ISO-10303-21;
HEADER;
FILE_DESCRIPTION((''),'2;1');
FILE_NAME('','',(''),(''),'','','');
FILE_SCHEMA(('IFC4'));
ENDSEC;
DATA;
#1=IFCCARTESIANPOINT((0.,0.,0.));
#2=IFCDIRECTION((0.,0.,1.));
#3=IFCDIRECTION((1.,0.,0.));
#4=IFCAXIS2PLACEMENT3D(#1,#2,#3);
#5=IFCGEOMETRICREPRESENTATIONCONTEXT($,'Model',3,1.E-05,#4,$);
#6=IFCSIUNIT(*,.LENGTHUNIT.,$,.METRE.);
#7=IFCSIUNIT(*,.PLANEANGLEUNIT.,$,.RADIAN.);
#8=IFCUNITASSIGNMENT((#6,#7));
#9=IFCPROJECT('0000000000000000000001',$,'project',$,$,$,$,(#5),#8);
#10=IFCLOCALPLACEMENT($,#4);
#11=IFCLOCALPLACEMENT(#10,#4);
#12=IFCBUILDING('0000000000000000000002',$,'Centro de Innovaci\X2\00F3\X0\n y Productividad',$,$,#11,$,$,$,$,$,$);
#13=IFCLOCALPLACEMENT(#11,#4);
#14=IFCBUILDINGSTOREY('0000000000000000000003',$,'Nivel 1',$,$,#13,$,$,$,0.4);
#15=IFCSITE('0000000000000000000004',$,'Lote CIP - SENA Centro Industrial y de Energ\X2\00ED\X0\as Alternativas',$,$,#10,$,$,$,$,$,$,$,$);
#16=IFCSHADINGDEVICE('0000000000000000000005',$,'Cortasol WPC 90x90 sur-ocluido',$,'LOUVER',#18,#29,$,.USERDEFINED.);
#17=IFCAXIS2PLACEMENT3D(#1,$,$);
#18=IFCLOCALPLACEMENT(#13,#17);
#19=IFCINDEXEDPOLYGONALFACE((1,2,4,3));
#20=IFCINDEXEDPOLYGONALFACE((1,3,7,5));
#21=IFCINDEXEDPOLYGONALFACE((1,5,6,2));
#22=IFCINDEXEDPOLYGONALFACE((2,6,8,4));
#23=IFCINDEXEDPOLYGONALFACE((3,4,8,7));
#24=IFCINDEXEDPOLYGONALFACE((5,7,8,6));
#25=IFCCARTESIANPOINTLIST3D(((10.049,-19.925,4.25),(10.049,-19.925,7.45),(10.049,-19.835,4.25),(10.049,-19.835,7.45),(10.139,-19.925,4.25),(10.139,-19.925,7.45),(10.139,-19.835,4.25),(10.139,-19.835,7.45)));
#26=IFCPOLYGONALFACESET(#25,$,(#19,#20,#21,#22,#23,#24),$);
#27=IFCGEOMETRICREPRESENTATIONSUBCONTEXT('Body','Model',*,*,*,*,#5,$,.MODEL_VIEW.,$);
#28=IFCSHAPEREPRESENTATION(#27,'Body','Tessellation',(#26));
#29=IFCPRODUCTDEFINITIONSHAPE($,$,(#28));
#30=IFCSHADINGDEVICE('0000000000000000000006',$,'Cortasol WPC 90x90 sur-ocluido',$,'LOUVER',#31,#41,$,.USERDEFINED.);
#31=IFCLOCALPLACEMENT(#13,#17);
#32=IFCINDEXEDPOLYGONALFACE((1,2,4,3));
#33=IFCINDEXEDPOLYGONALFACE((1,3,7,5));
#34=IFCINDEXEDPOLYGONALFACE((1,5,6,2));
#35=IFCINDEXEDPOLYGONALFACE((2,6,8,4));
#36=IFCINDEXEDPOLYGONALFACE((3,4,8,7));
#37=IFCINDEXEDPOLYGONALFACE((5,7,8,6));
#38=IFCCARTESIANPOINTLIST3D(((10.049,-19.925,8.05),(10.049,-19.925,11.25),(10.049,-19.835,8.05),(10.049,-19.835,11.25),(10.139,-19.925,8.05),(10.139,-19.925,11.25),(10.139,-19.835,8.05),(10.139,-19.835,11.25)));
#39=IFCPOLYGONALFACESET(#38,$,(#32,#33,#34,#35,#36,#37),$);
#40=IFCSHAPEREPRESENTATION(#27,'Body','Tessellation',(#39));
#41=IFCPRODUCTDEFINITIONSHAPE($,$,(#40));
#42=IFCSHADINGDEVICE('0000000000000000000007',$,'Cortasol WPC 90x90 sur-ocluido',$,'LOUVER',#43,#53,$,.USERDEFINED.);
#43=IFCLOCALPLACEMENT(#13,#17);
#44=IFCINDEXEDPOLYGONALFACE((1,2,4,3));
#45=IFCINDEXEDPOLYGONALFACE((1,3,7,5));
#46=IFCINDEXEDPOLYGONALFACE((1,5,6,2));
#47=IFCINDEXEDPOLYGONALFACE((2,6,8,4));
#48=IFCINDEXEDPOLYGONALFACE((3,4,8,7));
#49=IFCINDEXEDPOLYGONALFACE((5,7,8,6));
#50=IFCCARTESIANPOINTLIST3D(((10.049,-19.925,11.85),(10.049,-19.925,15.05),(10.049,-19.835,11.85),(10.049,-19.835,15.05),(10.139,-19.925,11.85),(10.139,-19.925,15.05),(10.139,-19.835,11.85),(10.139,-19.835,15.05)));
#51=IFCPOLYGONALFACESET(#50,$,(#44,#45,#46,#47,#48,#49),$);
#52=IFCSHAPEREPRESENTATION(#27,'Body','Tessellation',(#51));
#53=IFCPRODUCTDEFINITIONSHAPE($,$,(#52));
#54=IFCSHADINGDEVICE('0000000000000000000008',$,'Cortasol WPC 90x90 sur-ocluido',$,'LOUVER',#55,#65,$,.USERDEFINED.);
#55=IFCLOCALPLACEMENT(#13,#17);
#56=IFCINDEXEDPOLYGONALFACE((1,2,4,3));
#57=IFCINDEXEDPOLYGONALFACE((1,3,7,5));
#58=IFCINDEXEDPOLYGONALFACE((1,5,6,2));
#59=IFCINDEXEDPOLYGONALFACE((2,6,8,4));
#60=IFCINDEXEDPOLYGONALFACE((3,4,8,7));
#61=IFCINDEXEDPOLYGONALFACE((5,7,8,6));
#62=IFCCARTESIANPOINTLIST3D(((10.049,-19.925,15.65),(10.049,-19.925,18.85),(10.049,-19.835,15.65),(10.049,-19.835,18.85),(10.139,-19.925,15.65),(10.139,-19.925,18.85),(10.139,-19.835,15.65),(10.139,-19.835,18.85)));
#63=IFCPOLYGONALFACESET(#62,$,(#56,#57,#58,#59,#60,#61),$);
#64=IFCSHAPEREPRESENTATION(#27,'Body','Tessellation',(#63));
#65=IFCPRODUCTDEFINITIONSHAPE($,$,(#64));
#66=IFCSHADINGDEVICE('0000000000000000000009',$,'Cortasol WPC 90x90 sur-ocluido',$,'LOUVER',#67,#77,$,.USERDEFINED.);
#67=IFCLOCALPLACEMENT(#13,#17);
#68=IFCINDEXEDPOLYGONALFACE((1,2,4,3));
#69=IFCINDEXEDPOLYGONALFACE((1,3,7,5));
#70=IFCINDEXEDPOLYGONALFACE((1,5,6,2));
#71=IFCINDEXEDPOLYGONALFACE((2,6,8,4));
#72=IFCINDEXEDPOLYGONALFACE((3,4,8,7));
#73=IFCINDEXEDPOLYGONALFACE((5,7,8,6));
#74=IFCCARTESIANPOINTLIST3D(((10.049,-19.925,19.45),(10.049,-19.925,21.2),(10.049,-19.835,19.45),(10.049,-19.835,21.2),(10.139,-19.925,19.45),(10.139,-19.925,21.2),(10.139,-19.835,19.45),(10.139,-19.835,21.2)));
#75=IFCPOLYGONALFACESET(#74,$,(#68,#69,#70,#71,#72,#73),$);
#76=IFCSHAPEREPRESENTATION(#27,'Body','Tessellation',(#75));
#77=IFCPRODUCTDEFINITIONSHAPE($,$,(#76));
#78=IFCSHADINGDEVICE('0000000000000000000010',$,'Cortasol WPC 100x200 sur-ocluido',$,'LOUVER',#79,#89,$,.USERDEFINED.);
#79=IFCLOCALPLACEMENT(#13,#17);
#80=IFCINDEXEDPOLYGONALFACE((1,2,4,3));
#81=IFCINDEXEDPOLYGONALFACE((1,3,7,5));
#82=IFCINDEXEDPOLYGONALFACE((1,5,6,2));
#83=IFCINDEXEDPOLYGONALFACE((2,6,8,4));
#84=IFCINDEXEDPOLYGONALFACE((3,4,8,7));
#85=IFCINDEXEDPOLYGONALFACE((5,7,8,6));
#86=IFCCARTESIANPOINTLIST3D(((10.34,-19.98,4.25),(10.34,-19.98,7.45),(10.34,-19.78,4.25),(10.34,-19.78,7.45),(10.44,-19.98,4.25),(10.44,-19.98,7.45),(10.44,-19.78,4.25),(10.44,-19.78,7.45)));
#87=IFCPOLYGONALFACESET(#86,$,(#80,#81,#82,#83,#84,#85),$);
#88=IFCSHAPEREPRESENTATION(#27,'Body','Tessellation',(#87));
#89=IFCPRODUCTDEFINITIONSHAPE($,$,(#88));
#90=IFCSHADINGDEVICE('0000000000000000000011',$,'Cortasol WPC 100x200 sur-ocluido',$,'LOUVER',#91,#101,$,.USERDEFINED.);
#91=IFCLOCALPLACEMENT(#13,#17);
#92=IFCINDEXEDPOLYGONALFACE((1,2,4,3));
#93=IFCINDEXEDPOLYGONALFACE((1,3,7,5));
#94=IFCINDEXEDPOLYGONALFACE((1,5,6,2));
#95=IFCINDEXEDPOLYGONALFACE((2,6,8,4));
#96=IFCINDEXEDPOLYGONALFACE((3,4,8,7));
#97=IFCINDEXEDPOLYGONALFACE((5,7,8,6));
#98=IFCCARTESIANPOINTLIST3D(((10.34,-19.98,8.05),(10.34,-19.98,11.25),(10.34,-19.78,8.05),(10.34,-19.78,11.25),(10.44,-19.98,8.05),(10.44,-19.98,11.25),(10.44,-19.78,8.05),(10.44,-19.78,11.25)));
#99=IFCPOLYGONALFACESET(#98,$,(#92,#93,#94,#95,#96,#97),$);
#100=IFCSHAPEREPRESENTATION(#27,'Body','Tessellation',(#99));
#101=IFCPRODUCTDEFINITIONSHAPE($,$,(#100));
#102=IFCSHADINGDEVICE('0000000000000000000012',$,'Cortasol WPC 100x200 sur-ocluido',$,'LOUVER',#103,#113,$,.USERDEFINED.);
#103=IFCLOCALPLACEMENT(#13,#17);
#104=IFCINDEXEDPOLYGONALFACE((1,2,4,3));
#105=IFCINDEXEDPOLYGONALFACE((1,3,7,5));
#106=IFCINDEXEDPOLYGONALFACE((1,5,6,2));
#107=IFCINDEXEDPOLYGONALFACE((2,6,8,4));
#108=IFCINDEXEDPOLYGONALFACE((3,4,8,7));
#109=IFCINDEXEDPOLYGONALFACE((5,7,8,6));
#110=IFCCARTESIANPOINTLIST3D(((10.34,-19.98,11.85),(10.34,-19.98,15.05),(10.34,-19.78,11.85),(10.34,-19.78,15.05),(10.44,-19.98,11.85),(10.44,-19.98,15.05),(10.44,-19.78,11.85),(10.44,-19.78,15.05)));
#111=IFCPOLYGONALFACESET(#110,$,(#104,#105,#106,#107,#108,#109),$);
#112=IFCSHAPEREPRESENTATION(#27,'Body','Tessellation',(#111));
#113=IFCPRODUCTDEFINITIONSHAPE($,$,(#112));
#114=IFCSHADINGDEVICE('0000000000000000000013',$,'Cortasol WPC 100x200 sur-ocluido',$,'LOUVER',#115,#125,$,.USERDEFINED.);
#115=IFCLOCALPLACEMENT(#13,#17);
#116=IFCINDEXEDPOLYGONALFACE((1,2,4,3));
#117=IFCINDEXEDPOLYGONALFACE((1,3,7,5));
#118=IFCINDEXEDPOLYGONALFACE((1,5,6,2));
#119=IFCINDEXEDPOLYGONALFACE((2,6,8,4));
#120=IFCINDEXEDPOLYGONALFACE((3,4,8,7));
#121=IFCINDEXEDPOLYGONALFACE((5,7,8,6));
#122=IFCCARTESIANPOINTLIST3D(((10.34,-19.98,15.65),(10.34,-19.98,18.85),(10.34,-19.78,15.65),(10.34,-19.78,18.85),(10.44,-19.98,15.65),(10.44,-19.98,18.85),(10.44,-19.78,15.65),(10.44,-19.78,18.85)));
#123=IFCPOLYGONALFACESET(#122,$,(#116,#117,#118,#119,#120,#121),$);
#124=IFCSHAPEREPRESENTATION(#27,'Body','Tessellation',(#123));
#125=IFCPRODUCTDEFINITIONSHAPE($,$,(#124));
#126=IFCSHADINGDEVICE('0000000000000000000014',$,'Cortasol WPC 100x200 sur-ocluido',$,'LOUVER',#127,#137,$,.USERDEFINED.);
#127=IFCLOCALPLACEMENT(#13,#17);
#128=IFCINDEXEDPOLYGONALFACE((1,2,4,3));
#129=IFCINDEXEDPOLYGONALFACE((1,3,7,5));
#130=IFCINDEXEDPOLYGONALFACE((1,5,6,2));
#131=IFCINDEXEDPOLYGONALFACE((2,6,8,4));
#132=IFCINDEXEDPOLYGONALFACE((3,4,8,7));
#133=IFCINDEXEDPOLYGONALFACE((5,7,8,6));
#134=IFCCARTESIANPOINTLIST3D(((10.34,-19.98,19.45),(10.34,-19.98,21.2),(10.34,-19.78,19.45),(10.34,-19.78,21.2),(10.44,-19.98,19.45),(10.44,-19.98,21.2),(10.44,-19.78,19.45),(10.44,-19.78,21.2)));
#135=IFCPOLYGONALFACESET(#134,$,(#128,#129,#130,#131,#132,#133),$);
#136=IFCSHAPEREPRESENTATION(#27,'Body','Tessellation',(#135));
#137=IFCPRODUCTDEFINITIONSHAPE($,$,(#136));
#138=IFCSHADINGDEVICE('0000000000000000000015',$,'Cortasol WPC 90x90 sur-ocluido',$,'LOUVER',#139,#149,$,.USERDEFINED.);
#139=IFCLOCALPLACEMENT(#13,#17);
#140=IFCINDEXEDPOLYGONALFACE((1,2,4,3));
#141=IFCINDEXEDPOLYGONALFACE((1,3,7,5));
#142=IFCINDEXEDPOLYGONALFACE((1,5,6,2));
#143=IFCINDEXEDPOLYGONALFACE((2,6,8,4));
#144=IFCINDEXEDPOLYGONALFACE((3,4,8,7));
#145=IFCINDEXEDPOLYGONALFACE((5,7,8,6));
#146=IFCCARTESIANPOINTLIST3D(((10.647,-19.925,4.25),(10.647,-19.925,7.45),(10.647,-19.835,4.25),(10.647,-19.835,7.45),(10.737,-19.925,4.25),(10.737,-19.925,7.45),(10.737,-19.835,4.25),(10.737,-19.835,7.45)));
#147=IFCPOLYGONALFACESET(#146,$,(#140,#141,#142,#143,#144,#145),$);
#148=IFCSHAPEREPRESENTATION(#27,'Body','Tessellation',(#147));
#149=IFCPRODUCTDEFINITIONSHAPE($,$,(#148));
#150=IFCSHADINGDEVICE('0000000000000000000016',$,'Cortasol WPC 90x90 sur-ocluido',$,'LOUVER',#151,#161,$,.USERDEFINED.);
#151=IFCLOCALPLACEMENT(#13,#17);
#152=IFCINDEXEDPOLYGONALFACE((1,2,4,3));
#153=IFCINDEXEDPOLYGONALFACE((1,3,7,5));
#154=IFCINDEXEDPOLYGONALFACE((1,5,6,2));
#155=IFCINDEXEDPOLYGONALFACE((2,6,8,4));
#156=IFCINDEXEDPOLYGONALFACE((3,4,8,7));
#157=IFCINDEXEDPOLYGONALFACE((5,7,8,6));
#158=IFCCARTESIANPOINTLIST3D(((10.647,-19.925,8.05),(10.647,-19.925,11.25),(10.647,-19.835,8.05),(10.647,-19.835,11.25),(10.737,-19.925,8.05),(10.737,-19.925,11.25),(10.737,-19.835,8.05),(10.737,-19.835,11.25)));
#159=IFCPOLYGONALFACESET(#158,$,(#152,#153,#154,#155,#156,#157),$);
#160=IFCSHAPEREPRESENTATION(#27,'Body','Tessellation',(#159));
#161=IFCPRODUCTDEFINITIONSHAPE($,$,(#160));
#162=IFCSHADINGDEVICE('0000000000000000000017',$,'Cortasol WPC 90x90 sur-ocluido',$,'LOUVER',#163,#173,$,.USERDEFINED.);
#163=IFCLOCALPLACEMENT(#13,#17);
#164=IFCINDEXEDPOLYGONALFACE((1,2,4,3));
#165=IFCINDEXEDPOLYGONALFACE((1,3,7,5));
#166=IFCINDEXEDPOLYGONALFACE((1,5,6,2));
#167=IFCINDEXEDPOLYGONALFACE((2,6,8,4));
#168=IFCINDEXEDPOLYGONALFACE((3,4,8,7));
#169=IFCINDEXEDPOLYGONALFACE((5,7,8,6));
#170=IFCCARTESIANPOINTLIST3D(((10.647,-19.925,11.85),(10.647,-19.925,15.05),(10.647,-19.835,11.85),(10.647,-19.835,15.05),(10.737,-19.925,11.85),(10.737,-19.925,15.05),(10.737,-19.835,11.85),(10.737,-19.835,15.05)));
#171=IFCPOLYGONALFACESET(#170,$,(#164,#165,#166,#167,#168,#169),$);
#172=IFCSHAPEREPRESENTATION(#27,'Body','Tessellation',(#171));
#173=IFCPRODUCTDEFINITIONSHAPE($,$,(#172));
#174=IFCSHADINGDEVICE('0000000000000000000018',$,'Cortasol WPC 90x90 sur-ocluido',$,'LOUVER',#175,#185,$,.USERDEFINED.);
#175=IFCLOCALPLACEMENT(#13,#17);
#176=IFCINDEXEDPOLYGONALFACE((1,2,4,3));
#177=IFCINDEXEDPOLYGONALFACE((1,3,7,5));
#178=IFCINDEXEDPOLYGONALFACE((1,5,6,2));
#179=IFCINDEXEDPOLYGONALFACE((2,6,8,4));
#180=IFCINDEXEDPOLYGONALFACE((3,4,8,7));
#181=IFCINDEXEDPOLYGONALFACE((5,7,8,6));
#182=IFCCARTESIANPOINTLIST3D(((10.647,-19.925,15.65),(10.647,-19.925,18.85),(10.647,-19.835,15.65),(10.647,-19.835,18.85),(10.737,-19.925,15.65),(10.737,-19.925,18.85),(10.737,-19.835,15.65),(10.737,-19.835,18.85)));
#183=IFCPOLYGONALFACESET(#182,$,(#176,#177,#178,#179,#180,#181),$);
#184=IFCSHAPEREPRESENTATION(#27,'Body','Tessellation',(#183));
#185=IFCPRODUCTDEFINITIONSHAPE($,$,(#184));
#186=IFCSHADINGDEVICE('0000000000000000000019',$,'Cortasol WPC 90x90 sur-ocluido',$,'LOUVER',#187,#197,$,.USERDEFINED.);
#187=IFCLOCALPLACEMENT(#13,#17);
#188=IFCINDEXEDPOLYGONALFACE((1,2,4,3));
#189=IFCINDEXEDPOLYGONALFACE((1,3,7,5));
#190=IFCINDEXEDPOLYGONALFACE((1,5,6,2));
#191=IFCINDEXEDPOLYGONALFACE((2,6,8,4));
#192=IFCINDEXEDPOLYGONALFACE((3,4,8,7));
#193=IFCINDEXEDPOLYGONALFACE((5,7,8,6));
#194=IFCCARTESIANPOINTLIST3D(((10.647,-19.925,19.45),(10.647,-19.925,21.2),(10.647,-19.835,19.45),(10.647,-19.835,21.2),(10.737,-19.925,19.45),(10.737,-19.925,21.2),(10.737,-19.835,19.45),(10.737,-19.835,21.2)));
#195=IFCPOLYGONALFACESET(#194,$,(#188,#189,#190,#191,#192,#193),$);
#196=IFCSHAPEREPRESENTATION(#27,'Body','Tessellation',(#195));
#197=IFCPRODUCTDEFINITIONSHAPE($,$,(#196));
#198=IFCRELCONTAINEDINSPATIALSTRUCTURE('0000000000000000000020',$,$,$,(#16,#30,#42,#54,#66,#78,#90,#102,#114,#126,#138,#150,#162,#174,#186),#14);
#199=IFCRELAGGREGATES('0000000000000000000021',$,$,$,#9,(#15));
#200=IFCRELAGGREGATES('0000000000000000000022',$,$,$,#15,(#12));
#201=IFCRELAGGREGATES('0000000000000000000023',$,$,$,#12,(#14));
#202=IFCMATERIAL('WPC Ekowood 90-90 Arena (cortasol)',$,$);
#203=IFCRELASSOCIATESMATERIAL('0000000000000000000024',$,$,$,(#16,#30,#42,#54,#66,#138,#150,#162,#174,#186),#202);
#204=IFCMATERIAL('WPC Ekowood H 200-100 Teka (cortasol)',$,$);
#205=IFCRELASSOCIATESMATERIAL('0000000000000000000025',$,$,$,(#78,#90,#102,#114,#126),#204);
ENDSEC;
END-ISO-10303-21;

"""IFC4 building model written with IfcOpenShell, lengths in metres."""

from ifc_helpers import new_model, si_unit, frame, origin_with_axes, place, context, subcontext, project, spatial, polyline, outline, extrude, material, element, save


model = new_model("IFC4")

# Units and contexts
model_context = context("Model", 3, precision=1e-05, world=origin_with_axes())
body_context = subcontext(model_context, "Body", "Model", "MODEL_VIEW")
ifc_project = project(units=[si_unit("LENGTHUNIT", "METRE"), si_unit("PLANEANGLEUNIT", "RADIAN")], contexts=[model_context])

# Site, building, storey
site_placement = place(None, origin_with_axes())
site = spatial("IfcSite", under=ifc_project, at=site_placement, Name="Lote CIP - SENA Centro Industrial y de Energías Alternativas")
building_placement = place(site_placement, origin_with_axes())
building = spatial("IfcBuilding", under=site, at=building_placement, Name="Centro de Innovación y Productividad")
storey_placement = place(building_placement, origin_with_axes())
storey = spatial("IfcBuildingStorey", under=building, at=storey_placement, Name="Nivel 1", Elevation=0.4)

# Shading devices
ifc_material_1 = material(Name="WPC Ekowood 90-90 Arena (cortasol)")
shading_device_1_placement = place(storey_placement, origin_with_axes())
element("IfcShadingDevice", 1, at=shading_device_1_placement, inside=storey, material=ifc_material_1, Name="Cortasol WPC 90x90 sur-ocluido", ObjectType="LOUVER", PredefinedType="USERDEFINED", context=body_context, shape_type="SweptSolid", body=[
    extrude(outline(polyline([(10.049, -19.925), (10.049, -19.835), (10.139, -19.835), (10.139, -19.925), (10.049, -19.925)])), frame((0.0, 0.0, 4.25)), (0.0, 0.0, 1.0), 3.2),
])
shading_device_2_placement = place(storey_placement, origin_with_axes())
element("IfcShadingDevice", 2, at=shading_device_2_placement, inside=storey, material=ifc_material_1, Name="Cortasol WPC 90x90 sur-ocluido", ObjectType="LOUVER", PredefinedType="USERDEFINED", context=body_context, shape_type="SweptSolid", body=[
    extrude(outline(polyline([(10.049, -19.925), (10.049, -19.835), (10.139, -19.835), (10.139, -19.925), (10.049, -19.925)])), frame((0.0, 0.0, 8.05)), (0.0, 0.0, 1.0), 3.2),
])
shading_device_3_placement = place(storey_placement, origin_with_axes())
element("IfcShadingDevice", 3, at=shading_device_3_placement, inside=storey, material=ifc_material_1, Name="Cortasol WPC 90x90 sur-ocluido", ObjectType="LOUVER", PredefinedType="USERDEFINED", context=body_context, shape_type="SweptSolid", body=[
    extrude(outline(polyline([(10.049, -19.925), (10.049, -19.835), (10.139, -19.835), (10.139, -19.925), (10.049, -19.925)])), frame((0.0, 0.0, 11.85)), (0.0, 0.0, 1.0), 3.2),
])
shading_device_4_placement = place(storey_placement, origin_with_axes())
element("IfcShadingDevice", 4, at=shading_device_4_placement, inside=storey, material=ifc_material_1, Name="Cortasol WPC 90x90 sur-ocluido", ObjectType="LOUVER", PredefinedType="USERDEFINED", context=body_context, shape_type="SweptSolid", body=[
    extrude(outline(polyline([(10.049, -19.925), (10.049, -19.835), (10.139, -19.835), (10.139, -19.925), (10.049, -19.925)])), frame((0.0, 0.0, 15.65)), (0.0, 0.0, 1.0), 3.2),
])
shading_device_5_placement = place(storey_placement, origin_with_axes())
element("IfcShadingDevice", 5, at=shading_device_5_placement, inside=storey, material=ifc_material_1, Name="Cortasol WPC 90x90 sur-ocluido", ObjectType="LOUVER", PredefinedType="USERDEFINED", context=body_context, shape_type="SweptSolid", body=[
    extrude(outline(polyline([(10.049, -19.925), (10.049, -19.835), (10.139, -19.835), (10.139, -19.925), (10.049, -19.925)])), frame((0.0, 0.0, 19.45)), (0.0, 0.0, 1.0), 1.75),
])
ifc_material_2 = material(Name="WPC Ekowood H 200-100 Teka (cortasol)")
shading_device_6_placement = place(storey_placement, origin_with_axes())
element("IfcShadingDevice", 6, at=shading_device_6_placement, inside=storey, material=ifc_material_2, Name="Cortasol WPC 100x200 sur-ocluido", ObjectType="LOUVER", PredefinedType="USERDEFINED", context=body_context, shape_type="SweptSolid", body=[
    extrude(outline(polyline([(10.34, -19.98), (10.34, -19.78), (10.44, -19.78), (10.44, -19.98), (10.34, -19.98)])), frame((0.0, 0.0, 4.25)), (0.0, 0.0, 1.0), 3.2),
])
shading_device_7_placement = place(storey_placement, origin_with_axes())
element("IfcShadingDevice", 7, at=shading_device_7_placement, inside=storey, material=ifc_material_2, Name="Cortasol WPC 100x200 sur-ocluido", ObjectType="LOUVER", PredefinedType="USERDEFINED", context=body_context, shape_type="SweptSolid", body=[
    extrude(outline(polyline([(10.34, -19.98), (10.34, -19.78), (10.44, -19.78), (10.44, -19.98), (10.34, -19.98)])), frame((0.0, 0.0, 8.05)), (0.0, 0.0, 1.0), 3.2),
])
shading_device_8_placement = place(storey_placement, origin_with_axes())
element("IfcShadingDevice", 8, at=shading_device_8_placement, inside=storey, material=ifc_material_2, Name="Cortasol WPC 100x200 sur-ocluido", ObjectType="LOUVER", PredefinedType="USERDEFINED", context=body_context, shape_type="SweptSolid", body=[
    extrude(outline(polyline([(10.34, -19.98), (10.34, -19.78), (10.44, -19.78), (10.44, -19.98), (10.34, -19.98)])), frame((0.0, 0.0, 11.85)), (0.0, 0.0, 1.0), 3.2),
])
shading_device_9_placement = place(storey_placement, origin_with_axes())
element("IfcShadingDevice", 9, at=shading_device_9_placement, inside=storey, material=ifc_material_2, Name="Cortasol WPC 100x200 sur-ocluido", ObjectType="LOUVER", PredefinedType="USERDEFINED", context=body_context, shape_type="SweptSolid", body=[
    extrude(outline(polyline([(10.34, -19.98), (10.34, -19.78), (10.44, -19.78), (10.44, -19.98), (10.34, -19.98)])), frame((0.0, 0.0, 15.65)), (0.0, 0.0, 1.0), 3.2),
])
shading_device_10_placement = place(storey_placement, origin_with_axes())
element("IfcShadingDevice", 10, at=shading_device_10_placement, inside=storey, material=ifc_material_2, Name="Cortasol WPC 100x200 sur-ocluido", ObjectType="LOUVER", PredefinedType="USERDEFINED", context=body_context, shape_type="SweptSolid", body=[
    extrude(outline(polyline([(10.34, -19.98), (10.34, -19.78), (10.44, -19.78), (10.44, -19.98), (10.34, -19.98)])), frame((0.0, 0.0, 19.45)), (0.0, 0.0, 1.0), 1.75),
])
shading_device_11_placement = place(storey_placement, origin_with_axes())
element("IfcShadingDevice", 11, at=shading_device_11_placement, inside=storey, material=ifc_material_1, Name="Cortasol WPC 90x90 sur-ocluido", ObjectType="LOUVER", PredefinedType="USERDEFINED", context=body_context, shape_type="SweptSolid", body=[
    extrude(outline(polyline([(10.647, -19.925), (10.647, -19.835), (10.737, -19.835), (10.737, -19.925), (10.647, -19.925)])), frame((0.0, 0.0, 4.25)), (0.0, 0.0, 1.0), 3.2),
])
shading_device_12_placement = place(storey_placement, origin_with_axes())
element("IfcShadingDevice", 12, at=shading_device_12_placement, inside=storey, material=ifc_material_1, Name="Cortasol WPC 90x90 sur-ocluido", ObjectType="LOUVER", PredefinedType="USERDEFINED", context=body_context, shape_type="SweptSolid", body=[
    extrude(outline(polyline([(10.647, -19.925), (10.647, -19.835), (10.737, -19.835), (10.737, -19.925), (10.647, -19.925)])), frame((0.0, 0.0, 8.05)), (0.0, 0.0, 1.0), 3.2),
])
shading_device_13_placement = place(storey_placement, origin_with_axes())
element("IfcShadingDevice", 13, at=shading_device_13_placement, inside=storey, material=ifc_material_1, Name="Cortasol WPC 90x90 sur-ocluido", ObjectType="LOUVER", PredefinedType="USERDEFINED", context=body_context, shape_type="SweptSolid", body=[
    extrude(outline(polyline([(10.647, -19.925), (10.647, -19.835), (10.737, -19.835), (10.737, -19.925), (10.647, -19.925)])), frame((0.0, 0.0, 11.85)), (0.0, 0.0, 1.0), 3.2),
])
shading_device_14_placement = place(storey_placement, origin_with_axes())
element("IfcShadingDevice", 14, at=shading_device_14_placement, inside=storey, material=ifc_material_1, Name="Cortasol WPC 90x90 sur-ocluido", ObjectType="LOUVER", PredefinedType="USERDEFINED", context=body_context, shape_type="SweptSolid", body=[
    extrude(outline(polyline([(10.647, -19.925), (10.647, -19.835), (10.737, -19.835), (10.737, -19.925), (10.647, -19.925)])), frame((0.0, 0.0, 15.65)), (0.0, 0.0, 1.0), 3.2),
])
shading_device_15_placement = place(storey_placement, origin_with_axes())
element("IfcShadingDevice", 15, at=shading_device_15_placement, inside=storey, material=ifc_material_1, Name="Cortasol WPC 90x90 sur-ocluido", ObjectType="LOUVER", PredefinedType="USERDEFINED", context=body_context, shape_type="SweptSolid", body=[
    extrude(outline(polyline([(10.647, -19.925), (10.647, -19.835), (10.737, -19.835), (10.737, -19.925), (10.647, -19.925)])), frame((0.0, 0.0, 19.45)), (0.0, 0.0, 1.0), 1.75),
])

save(model, "model.ifc")
